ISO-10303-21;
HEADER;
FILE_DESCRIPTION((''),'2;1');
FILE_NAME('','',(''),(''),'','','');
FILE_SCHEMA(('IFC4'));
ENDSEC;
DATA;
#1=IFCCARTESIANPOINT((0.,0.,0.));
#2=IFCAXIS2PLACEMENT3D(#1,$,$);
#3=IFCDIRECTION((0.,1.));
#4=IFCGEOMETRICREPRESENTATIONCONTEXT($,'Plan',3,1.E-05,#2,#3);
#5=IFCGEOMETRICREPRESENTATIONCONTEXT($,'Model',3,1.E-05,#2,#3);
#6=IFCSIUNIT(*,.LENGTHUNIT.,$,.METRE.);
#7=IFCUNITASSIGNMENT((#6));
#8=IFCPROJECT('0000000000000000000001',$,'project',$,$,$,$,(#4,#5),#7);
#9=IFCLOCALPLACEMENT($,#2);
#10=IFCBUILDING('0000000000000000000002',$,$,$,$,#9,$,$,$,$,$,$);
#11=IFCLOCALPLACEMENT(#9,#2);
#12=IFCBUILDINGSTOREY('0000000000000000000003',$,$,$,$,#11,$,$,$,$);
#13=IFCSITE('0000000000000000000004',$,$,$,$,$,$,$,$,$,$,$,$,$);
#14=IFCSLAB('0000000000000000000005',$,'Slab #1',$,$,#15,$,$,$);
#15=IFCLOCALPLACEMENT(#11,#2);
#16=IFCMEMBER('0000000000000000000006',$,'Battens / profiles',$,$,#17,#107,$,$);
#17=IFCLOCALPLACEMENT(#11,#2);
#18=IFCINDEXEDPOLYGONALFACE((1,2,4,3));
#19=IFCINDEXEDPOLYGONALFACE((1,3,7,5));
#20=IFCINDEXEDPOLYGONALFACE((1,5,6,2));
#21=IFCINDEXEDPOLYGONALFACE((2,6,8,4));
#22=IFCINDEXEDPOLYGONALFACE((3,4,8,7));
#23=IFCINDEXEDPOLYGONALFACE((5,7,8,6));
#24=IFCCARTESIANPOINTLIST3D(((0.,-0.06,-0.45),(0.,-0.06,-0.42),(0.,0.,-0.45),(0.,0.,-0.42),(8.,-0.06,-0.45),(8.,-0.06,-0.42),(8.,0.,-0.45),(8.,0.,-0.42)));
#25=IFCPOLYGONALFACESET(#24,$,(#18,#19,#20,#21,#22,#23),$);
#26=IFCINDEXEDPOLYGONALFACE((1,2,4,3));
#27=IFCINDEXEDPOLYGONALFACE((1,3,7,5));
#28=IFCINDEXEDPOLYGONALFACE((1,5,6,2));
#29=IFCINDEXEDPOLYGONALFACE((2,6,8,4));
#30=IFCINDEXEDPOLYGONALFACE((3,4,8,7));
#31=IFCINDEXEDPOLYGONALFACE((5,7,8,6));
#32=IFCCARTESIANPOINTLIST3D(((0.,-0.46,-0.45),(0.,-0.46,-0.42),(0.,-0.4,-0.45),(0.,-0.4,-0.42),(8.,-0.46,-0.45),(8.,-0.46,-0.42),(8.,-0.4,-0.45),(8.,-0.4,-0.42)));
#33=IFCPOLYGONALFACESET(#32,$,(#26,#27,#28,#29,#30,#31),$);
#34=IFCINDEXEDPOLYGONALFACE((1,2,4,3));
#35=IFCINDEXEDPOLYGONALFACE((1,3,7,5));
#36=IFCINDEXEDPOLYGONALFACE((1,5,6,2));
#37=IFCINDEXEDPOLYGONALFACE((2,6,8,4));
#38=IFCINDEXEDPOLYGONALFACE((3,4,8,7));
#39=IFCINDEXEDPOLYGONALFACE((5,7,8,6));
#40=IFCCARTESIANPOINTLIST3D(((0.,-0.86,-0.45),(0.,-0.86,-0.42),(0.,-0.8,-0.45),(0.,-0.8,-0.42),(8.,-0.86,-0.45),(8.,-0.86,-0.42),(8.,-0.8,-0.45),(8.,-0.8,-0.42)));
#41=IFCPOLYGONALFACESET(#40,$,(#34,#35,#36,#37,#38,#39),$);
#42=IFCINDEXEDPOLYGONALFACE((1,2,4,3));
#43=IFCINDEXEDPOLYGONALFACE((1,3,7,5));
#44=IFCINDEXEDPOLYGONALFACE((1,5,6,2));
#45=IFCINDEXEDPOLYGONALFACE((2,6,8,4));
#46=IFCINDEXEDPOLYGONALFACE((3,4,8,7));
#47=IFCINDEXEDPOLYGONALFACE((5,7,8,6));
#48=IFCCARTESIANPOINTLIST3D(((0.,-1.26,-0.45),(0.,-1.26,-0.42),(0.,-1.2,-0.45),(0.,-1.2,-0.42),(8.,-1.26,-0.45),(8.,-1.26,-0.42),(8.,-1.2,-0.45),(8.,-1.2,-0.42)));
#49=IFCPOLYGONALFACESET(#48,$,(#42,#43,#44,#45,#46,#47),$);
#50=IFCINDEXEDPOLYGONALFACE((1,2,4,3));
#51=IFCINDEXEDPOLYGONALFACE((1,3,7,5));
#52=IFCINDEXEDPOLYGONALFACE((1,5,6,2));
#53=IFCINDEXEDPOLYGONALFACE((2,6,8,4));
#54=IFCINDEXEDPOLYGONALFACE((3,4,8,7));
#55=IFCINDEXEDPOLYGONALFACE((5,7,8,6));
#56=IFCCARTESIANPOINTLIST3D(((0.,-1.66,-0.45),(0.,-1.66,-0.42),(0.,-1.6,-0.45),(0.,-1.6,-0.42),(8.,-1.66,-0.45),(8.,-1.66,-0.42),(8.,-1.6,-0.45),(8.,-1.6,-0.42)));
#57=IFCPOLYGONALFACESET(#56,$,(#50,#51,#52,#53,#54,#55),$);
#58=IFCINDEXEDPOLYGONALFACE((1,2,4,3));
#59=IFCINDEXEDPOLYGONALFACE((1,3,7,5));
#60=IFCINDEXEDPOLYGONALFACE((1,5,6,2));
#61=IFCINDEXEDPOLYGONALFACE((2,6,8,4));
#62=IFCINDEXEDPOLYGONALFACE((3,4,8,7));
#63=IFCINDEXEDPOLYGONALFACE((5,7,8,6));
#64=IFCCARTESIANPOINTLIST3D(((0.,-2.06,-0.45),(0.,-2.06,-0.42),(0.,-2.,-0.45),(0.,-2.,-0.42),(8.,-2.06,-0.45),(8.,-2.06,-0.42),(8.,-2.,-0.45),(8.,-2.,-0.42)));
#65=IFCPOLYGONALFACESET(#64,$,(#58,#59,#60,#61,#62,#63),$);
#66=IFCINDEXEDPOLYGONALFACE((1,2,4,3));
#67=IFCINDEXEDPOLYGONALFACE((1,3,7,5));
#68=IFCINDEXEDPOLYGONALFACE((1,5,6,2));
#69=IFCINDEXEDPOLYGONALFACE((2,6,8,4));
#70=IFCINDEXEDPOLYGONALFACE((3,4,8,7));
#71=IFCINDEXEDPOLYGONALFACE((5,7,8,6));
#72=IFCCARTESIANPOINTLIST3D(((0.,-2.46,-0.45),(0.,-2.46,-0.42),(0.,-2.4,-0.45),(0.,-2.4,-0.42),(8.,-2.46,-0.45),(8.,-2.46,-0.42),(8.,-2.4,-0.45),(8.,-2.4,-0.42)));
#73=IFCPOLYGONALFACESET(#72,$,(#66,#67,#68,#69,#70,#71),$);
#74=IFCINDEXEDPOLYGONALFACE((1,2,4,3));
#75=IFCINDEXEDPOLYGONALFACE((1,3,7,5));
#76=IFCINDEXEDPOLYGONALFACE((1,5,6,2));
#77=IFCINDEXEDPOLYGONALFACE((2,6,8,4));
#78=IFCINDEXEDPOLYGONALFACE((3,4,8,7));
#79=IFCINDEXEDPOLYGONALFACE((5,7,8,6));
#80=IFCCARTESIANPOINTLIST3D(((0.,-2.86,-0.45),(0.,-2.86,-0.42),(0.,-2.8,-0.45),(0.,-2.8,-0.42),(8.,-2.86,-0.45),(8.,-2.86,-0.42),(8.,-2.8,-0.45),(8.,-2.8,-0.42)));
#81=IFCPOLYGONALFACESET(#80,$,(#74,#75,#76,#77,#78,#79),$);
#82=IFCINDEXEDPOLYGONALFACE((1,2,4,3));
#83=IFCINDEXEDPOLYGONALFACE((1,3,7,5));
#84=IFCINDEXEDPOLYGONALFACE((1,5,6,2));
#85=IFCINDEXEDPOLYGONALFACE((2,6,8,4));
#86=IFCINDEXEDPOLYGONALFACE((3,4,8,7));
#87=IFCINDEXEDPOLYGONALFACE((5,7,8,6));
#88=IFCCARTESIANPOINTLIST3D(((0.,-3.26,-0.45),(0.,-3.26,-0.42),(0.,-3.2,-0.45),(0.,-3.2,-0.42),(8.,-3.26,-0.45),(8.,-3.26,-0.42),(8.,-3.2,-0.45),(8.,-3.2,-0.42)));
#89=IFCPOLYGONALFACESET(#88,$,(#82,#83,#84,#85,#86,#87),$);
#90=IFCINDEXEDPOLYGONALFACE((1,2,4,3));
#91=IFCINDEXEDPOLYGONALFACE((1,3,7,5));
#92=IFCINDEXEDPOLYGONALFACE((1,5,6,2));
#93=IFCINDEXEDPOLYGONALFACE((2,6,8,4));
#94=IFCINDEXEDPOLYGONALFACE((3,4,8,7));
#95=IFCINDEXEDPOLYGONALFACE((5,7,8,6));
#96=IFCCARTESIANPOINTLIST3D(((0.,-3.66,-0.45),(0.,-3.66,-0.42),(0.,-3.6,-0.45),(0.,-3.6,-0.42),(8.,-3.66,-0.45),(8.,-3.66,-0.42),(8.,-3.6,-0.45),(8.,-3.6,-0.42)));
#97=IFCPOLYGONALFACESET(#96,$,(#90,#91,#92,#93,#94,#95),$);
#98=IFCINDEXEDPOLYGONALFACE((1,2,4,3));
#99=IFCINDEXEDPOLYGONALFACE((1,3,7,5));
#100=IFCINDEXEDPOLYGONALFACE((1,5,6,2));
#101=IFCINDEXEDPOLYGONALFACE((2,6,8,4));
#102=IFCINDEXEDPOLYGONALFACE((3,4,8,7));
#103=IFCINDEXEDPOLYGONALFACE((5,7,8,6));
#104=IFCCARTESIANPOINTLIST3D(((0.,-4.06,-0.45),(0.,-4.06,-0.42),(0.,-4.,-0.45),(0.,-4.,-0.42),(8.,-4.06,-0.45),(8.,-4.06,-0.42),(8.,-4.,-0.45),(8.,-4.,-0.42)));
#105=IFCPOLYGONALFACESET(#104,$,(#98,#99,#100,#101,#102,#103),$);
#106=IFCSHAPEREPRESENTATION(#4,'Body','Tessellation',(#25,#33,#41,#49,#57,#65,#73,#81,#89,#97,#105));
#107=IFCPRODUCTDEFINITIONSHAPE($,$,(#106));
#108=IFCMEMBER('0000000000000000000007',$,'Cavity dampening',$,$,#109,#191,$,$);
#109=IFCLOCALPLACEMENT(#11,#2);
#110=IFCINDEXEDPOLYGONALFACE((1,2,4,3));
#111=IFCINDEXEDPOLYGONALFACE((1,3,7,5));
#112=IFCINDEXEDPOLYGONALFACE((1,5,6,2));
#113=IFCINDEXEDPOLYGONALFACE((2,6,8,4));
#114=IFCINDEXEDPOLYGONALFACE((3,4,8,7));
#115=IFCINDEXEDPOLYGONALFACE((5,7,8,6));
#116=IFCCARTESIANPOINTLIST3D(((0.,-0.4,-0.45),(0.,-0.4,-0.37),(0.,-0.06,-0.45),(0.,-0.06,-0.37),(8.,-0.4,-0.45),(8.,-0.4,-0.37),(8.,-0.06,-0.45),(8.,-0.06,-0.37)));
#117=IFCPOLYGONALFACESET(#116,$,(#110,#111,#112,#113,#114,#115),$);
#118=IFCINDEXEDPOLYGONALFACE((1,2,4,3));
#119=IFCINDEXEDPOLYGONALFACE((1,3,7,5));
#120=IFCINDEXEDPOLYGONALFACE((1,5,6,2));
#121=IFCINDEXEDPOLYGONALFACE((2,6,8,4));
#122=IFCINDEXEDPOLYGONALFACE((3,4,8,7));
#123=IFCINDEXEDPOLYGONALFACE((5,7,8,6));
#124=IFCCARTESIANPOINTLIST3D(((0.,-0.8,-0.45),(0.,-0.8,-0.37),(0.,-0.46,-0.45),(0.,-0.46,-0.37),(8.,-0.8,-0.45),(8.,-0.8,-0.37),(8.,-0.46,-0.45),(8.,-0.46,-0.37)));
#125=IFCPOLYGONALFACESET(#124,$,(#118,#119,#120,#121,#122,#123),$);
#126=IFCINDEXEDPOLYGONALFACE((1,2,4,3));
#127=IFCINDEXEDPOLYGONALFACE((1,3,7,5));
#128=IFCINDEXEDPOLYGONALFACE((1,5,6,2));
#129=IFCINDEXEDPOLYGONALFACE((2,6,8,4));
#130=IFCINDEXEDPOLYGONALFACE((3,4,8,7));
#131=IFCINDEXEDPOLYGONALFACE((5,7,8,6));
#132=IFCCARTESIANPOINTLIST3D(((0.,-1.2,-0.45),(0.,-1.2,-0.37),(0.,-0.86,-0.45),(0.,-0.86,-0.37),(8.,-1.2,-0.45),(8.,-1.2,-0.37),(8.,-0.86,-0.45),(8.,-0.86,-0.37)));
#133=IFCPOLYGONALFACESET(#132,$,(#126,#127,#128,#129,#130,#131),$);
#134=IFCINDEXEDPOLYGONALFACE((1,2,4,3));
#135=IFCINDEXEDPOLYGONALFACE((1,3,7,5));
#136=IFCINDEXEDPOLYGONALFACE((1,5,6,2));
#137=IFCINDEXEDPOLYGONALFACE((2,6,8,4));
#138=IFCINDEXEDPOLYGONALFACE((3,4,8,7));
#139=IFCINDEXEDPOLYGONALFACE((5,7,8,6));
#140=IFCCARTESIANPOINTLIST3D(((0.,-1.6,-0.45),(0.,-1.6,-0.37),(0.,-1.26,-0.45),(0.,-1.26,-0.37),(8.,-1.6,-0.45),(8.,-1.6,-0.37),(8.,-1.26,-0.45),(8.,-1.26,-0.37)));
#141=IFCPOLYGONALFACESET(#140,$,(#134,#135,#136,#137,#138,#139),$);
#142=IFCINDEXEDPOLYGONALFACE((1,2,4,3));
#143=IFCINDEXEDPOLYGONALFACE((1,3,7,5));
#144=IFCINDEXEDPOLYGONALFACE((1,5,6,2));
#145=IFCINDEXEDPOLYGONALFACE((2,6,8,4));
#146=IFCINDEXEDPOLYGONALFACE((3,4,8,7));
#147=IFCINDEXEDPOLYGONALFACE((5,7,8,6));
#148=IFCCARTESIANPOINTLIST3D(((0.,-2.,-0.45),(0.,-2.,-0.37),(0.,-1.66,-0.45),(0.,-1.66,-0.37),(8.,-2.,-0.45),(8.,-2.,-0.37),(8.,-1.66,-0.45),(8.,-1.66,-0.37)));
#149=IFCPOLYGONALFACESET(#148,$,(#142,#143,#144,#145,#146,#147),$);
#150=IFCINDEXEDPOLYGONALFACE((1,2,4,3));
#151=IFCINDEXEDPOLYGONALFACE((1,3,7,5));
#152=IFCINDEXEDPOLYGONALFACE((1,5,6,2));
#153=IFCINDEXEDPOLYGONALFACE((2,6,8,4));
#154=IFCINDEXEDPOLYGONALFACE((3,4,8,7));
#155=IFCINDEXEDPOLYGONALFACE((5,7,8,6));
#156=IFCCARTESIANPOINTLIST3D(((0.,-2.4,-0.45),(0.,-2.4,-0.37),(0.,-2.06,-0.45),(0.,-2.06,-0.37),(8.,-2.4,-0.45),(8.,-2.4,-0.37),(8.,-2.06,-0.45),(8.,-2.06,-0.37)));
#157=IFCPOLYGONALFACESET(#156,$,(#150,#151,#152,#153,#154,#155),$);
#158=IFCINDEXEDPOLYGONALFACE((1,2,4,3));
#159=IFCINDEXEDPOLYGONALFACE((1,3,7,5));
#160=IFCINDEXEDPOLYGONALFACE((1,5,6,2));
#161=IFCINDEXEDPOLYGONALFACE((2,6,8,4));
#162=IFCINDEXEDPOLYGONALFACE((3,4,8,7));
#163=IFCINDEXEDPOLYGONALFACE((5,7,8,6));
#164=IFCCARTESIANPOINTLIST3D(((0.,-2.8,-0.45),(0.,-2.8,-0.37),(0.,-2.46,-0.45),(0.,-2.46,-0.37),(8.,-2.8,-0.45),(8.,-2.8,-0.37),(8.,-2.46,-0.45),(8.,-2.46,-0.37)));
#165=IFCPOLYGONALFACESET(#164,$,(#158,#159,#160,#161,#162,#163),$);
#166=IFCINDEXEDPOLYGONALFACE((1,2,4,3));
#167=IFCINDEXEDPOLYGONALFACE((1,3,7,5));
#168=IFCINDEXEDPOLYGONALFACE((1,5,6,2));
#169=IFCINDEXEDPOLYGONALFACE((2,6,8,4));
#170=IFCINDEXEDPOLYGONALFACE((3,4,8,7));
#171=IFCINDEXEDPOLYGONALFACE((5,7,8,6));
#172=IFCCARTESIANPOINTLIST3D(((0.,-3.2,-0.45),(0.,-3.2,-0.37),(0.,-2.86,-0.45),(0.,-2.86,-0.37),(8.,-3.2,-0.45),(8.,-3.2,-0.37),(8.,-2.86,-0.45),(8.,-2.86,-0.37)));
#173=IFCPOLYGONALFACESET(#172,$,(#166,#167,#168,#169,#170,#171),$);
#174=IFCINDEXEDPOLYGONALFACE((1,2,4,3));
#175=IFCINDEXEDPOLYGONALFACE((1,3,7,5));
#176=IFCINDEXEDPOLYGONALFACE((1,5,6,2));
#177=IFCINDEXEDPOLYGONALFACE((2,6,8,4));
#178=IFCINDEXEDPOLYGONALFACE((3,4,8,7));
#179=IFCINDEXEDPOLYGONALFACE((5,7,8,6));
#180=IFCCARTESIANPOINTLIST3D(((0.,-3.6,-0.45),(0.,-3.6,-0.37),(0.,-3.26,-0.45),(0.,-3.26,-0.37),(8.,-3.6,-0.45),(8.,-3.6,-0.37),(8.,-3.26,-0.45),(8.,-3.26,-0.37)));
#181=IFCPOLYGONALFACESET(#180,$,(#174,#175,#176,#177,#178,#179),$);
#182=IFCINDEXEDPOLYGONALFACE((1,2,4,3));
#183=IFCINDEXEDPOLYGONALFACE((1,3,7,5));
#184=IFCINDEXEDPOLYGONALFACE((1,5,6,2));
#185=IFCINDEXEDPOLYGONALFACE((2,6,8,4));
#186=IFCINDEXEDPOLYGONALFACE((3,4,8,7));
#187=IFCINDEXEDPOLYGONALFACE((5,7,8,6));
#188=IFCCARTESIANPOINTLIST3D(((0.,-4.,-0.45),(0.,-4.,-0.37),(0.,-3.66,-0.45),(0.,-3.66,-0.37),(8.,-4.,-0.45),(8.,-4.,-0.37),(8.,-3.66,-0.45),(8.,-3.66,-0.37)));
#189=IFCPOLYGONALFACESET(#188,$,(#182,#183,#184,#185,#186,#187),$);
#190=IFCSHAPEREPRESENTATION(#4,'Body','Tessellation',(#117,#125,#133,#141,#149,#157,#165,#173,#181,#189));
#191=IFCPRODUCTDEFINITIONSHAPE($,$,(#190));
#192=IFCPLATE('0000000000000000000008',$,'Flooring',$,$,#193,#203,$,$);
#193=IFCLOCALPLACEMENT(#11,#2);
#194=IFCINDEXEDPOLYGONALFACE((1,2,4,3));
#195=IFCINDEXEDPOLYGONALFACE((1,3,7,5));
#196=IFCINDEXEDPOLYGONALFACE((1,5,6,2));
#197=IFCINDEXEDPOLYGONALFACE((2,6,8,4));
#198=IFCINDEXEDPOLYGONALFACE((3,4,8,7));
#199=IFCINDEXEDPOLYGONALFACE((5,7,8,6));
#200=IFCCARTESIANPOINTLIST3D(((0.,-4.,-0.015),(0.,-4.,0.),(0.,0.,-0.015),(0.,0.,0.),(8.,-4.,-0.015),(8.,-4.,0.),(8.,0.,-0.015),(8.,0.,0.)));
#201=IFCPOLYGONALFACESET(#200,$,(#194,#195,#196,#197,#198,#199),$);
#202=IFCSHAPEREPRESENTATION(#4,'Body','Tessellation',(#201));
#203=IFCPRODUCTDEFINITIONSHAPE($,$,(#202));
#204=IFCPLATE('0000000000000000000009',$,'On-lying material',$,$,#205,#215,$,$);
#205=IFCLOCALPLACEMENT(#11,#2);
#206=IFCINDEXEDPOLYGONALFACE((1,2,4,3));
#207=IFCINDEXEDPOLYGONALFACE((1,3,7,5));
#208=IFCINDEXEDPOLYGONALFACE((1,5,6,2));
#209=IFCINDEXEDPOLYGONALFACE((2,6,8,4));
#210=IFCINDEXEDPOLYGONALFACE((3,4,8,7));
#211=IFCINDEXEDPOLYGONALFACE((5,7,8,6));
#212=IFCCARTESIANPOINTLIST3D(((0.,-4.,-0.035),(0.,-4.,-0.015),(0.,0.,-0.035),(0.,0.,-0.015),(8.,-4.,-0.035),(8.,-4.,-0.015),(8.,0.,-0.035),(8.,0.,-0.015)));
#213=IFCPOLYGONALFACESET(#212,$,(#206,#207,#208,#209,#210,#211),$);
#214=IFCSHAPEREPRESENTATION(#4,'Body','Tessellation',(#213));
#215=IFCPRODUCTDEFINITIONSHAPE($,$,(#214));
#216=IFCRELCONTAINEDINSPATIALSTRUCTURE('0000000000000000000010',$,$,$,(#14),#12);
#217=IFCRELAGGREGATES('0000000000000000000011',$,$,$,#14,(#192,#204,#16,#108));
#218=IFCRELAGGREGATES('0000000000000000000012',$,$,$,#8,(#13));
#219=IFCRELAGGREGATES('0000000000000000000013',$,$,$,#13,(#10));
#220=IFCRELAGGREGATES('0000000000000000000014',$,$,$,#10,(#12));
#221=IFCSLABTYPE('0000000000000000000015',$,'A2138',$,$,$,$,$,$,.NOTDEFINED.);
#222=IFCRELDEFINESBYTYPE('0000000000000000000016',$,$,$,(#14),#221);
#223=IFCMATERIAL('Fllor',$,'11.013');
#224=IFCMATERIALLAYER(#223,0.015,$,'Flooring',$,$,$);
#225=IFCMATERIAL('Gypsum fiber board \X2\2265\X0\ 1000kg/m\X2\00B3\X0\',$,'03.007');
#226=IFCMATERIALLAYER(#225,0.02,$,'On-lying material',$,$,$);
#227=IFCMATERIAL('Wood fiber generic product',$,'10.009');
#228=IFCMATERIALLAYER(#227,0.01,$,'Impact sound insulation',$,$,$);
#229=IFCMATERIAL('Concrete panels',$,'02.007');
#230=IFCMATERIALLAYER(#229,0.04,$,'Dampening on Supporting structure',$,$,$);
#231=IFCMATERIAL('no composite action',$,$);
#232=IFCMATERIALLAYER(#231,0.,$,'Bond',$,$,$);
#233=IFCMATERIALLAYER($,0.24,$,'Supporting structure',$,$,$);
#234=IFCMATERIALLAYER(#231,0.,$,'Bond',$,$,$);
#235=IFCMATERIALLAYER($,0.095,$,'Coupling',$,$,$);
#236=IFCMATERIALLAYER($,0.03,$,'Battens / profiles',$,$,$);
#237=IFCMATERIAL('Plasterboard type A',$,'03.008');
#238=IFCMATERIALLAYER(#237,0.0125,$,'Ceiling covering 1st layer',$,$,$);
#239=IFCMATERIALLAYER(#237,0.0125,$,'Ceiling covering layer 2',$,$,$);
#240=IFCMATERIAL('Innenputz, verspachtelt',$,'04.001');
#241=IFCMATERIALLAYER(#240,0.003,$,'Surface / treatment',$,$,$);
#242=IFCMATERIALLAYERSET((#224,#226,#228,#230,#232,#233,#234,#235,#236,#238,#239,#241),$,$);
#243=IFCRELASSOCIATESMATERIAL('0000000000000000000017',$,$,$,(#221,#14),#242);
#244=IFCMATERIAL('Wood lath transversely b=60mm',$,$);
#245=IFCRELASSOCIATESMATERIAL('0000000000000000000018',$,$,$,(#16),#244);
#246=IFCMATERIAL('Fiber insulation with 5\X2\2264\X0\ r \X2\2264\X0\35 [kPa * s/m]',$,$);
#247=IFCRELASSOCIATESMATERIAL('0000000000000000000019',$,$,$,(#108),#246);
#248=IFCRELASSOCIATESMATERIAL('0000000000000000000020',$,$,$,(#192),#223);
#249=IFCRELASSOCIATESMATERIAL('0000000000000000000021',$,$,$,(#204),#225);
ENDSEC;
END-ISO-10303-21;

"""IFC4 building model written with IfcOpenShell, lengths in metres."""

from ifc_helpers import new_model, si_unit, direction, frame, frame_2d, origin, origin_with_axes, place, context, project, spatial, rectangle, extrude, material, layer, layer_set, type_object, element, aggregate, save


model = new_model("IFC4")

# Units and contexts
plan_context = context("Plan", 3, precision=1e-05, world=origin(), true_north=direction((0.0, 1.0)))
model_context = context("Model", 3, precision=1e-05, world=origin(), true_north=direction((0.0, 1.0)))
ifc_project = project(units=[si_unit("LENGTHUNIT", "METRE")], contexts=[plan_context, model_context])

# Site, building, storey
site = spatial("IfcSite", under=ifc_project)
building_placement = place(None, origin())
building = spatial("IfcBuilding", under=site, at=building_placement)
storey_placement = place(building_placement, origin())
storey = spatial("IfcBuildingStorey", under=building, at=storey_placement)

# Slab, members, plates
ifc_material_1 = material(Name="Fllor", Category="11.013")
ifc_layer_1 = layer(ifc_material_1, 0.015, Name="Flooring")
ifc_material_2 = material(Name="Gypsum fiber board ≥ 1000kg/m³", Category="03.007")
ifc_layer_2 = layer(ifc_material_2, 0.02, Name="On-lying material")
ifc_material_3 = material(Name="Wood fiber generic product", Category="10.009")
ifc_layer_3 = layer(ifc_material_3, 0.01, Name="Impact sound insulation")
ifc_material_4 = material(Name="Concrete panels", Category="02.007")
ifc_layer_4 = layer(ifc_material_4, 0.04, Name="Dampening on Supporting structure")
ifc_material_5 = material(Name="no composite action")
ifc_layer_5 = layer(ifc_material_5, 0.0, Name="Bond")
ifc_layer_6 = layer(None, 0.24, Name="Supporting structure")
ifc_layer_7 = layer(ifc_material_5, 0.0, Name="Bond")
ifc_layer_8 = layer(None, 0.095, Name="Coupling")
ifc_layer_9 = layer(None, 0.03, Name="Battens / profiles")
ifc_material_6 = material(Name="Plasterboard type A", Category="03.008")
ifc_layer_10 = layer(ifc_material_6, 0.0125, Name="Ceiling covering 1st layer")
ifc_layer_11 = layer(ifc_material_6, 0.0125, Name="Ceiling covering layer 2")
ifc_material_7 = material(Name="Innenputz, verspachtelt", Category="04.001")
ifc_layer_12 = layer(ifc_material_7, 0.003, Name="Surface / treatment")
ifc_layer_set = layer_set([ifc_layer_1, ifc_layer_2, ifc_layer_3, ifc_layer_4, ifc_layer_5, ifc_layer_6, ifc_layer_7, ifc_layer_8, ifc_layer_9, ifc_layer_10, ifc_layer_11, ifc_layer_12])
slab_type = type_object("IfcSlabType", Name="A2138", PredefinedType="NOTDEFINED", material=ifc_layer_set)
slab_placement = place(None, frame((0.0, 0.0, 0.0), z_axis=(0.0, 0.0, -1.0), x_axis=(1.0, 0.0, 0.0)))
slab = element("IfcSlab", 1, at=slab_placement, inside=storey, type_object=slab_type, material=ifc_layer_set, Name="Slab #1")
ifc_material_8 = material(Name="Wood lath transversely b=60mm")
member_1_placement = place(slab_placement, origin())
member_1 = element("IfcMember", 2, at=member_1_placement, material=ifc_material_8, Name="Battens / profiles", context=plan_context, shape_type="SweptSolid", body=[
    extrude(rectangle(XDim=0.06, YDim=0.03, at=frame_2d((0.03, 0.015), x_axis=(1.0, 0.0))), frame((0.0, 0.0, 0.42), z_axis=(1.0, 0.0, 0.0), x_axis=(0.0, 1.0, 0.0)), (0.0, 0.0, 1.0), 8.0),
    extrude(rectangle(XDim=0.06, YDim=0.03, at=frame_2d((0.03, 0.015), x_axis=(1.0, 0.0))), frame((0.0, 0.4, 0.42), z_axis=(1.0, 0.0, 0.0), x_axis=(0.0, 1.0, 0.0)), (0.0, 0.0, 1.0), 8.0),
    extrude(rectangle(XDim=0.06, YDim=0.03, at=frame_2d((0.03, 0.015), x_axis=(1.0, 0.0))), frame((0.0, 0.8, 0.42), z_axis=(1.0, 0.0, 0.0), x_axis=(0.0, 1.0, 0.0)), (0.0, 0.0, 1.0), 8.0),
    extrude(rectangle(XDim=0.06, YDim=0.03, at=frame_2d((0.03, 0.015), x_axis=(1.0, 0.0))), frame((0.0, 1.2, 0.42), z_axis=(1.0, 0.0, 0.0), x_axis=(0.0, 1.0, 0.0)), (0.0, 0.0, 1.0), 8.0),
    extrude(rectangle(XDim=0.06, YDim=0.03, at=frame_2d((0.03, 0.015), x_axis=(1.0, 0.0))), frame((0.0, 1.6, 0.42), z_axis=(1.0, 0.0, 0.0), x_axis=(0.0, 1.0, 0.0)), (0.0, 0.0, 1.0), 8.0),
    extrude(rectangle(XDim=0.06, YDim=0.03, at=frame_2d((0.03, 0.015), x_axis=(1.0, 0.0))), frame((0.0, 2.0, 0.42), z_axis=(1.0, 0.0, 0.0), x_axis=(0.0, 1.0, 0.0)), (0.0, 0.0, 1.0), 8.0),
    extrude(rectangle(XDim=0.06, YDim=0.03, at=frame_2d((0.03, 0.015), x_axis=(1.0, 0.0))), frame((0.0, 2.4, 0.42), z_axis=(1.0, 0.0, 0.0), x_axis=(0.0, 1.0, 0.0)), (0.0, 0.0, 1.0), 8.0),
    extrude(rectangle(XDim=0.06, YDim=0.03, at=frame_2d((0.03, 0.015), x_axis=(1.0, 0.0))), frame((0.0, 2.8, 0.42), z_axis=(1.0, 0.0, 0.0), x_axis=(0.0, 1.0, 0.0)), (0.0, 0.0, 1.0), 8.0),
    extrude(rectangle(XDim=0.06, YDim=0.03, at=frame_2d((0.03, 0.015), x_axis=(1.0, 0.0))), frame((0.0, 3.2, 0.42), z_axis=(1.0, 0.0, 0.0), x_axis=(0.0, 1.0, 0.0)), (0.0, 0.0, 1.0), 8.0),
    extrude(rectangle(XDim=0.06, YDim=0.03, at=frame_2d((0.03, 0.015), x_axis=(1.0, 0.0))), frame((0.0, 3.6, 0.42), z_axis=(1.0, 0.0, 0.0), x_axis=(0.0, 1.0, 0.0)), (0.0, 0.0, 1.0), 8.0),
    extrude(rectangle(XDim=0.06, YDim=0.03, at=frame_2d((0.03, 0.015), x_axis=(1.0, 0.0))), frame((0.0, 4.0, 0.42), z_axis=(1.0, 0.0, 0.0), x_axis=(0.0, 1.0, 0.0)), (0.0, 0.0, 1.0), 8.0),
])
ifc_material_9 = material(Name="Fiber insulation with 5≤ r ≤35 [kPa * s/m]")
member_2_placement = place(slab_placement, origin())
member_2 = element("IfcMember", 3, at=member_2_placement, material=ifc_material_9, Name="Cavity dampening", context=plan_context, shape_type="SweptSolid", body=[
    extrude(rectangle(XDim=0.34, YDim=0.08, at=frame_2d((0.17, 0.04), x_axis=(1.0, 0.0))), frame((0.0, 0.06, 0.37), z_axis=(1.0, 0.0, 0.0), x_axis=(0.0, 1.0, 0.0)), (0.0, 0.0, 1.0), 8.0),
    extrude(rectangle(XDim=0.34, YDim=0.08, at=frame_2d((0.17, 0.04), x_axis=(1.0, 0.0))), frame((0.0, 0.46, 0.37), z_axis=(1.0, 0.0, 0.0), x_axis=(0.0, 1.0, 0.0)), (0.0, 0.0, 1.0), 8.0),
    extrude(rectangle(XDim=0.34, YDim=0.08, at=frame_2d((0.17, 0.04), x_axis=(1.0, 0.0))), frame((0.0, 0.86, 0.37), z_axis=(1.0, 0.0, 0.0), x_axis=(0.0, 1.0, 0.0)), (0.0, 0.0, 1.0), 8.0),
    extrude(rectangle(XDim=0.34, YDim=0.08, at=frame_2d((0.17, 0.04), x_axis=(1.0, 0.0))), frame((0.0, 1.26, 0.37), z_axis=(1.0, 0.0, 0.0), x_axis=(0.0, 1.0, 0.0)), (0.0, 0.0, 1.0), 8.0),
    extrude(rectangle(XDim=0.34, YDim=0.08, at=frame_2d((0.17, 0.04), x_axis=(1.0, 0.0))), frame((0.0, 1.66, 0.37), z_axis=(1.0, 0.0, 0.0), x_axis=(0.0, 1.0, 0.0)), (0.0, 0.0, 1.0), 8.0),
    extrude(rectangle(XDim=0.34, YDim=0.08, at=frame_2d((0.17, 0.04), x_axis=(1.0, 0.0))), frame((0.0, 2.06, 0.37), z_axis=(1.0, 0.0, 0.0), x_axis=(0.0, 1.0, 0.0)), (0.0, 0.0, 1.0), 8.0),
    extrude(rectangle(XDim=0.34, YDim=0.08, at=frame_2d((0.17, 0.04), x_axis=(1.0, 0.0))), frame((0.0, 2.46, 0.37), z_axis=(1.0, 0.0, 0.0), x_axis=(0.0, 1.0, 0.0)), (0.0, 0.0, 1.0), 8.0),
    extrude(rectangle(XDim=0.34, YDim=0.08, at=frame_2d((0.17, 0.04), x_axis=(1.0, 0.0))), frame((0.0, 2.86, 0.37), z_axis=(1.0, 0.0, 0.0), x_axis=(0.0, 1.0, 0.0)), (0.0, 0.0, 1.0), 8.0),
    extrude(rectangle(XDim=0.34, YDim=0.08, at=frame_2d((0.17, 0.04), x_axis=(1.0, 0.0))), frame((0.0, 3.26, 0.37), z_axis=(1.0, 0.0, 0.0), x_axis=(0.0, 1.0, 0.0)), (0.0, 0.0, 1.0), 8.0),
    extrude(rectangle(XDim=0.34, YDim=0.08, at=frame_2d((0.17, 0.04), x_axis=(1.0, 0.0))), frame((0.0, 3.66, 0.37), z_axis=(1.0, 0.0, 0.0), x_axis=(0.0, 1.0, 0.0)), (0.0, 0.0, 1.0), 8.0),
])
plate_1_placement = place(slab_placement, origin())
plate_1 = element("IfcPlate", 4, at=plate_1_placement, material=ifc_material_1, Name="Flooring", context=plan_context, shape_type="SweptSolid", body=[
    extrude(rectangle(XDim=8.0, YDim=4.0, at=frame_2d((4.0, 2.0), x_axis=(1.0, 0.0))), origin_with_axes(), (0.0, 0.0, 1.0), 0.015),
])
plate_2_placement = place(slab_placement, origin())
plate_2 = element("IfcPlate", 5, at=plate_2_placement, material=ifc_material_2, Name="On-lying material", context=plan_context, shape_type="SweptSolid", body=[
    extrude(rectangle(XDim=8.0, YDim=4.0, at=frame_2d((4.0, 2.0), x_axis=(1.0, 0.0))), frame((0.0, 0.0, 0.015), z_axis=(0.0, 0.0, 1.0), x_axis=(1.0, 0.0, 0.0)), (0.0, 0.0, 1.0), 0.02),
])
aggregate(slab, [plate_1, plate_2, member_1, member_2])

save(model, "model.ifc")
